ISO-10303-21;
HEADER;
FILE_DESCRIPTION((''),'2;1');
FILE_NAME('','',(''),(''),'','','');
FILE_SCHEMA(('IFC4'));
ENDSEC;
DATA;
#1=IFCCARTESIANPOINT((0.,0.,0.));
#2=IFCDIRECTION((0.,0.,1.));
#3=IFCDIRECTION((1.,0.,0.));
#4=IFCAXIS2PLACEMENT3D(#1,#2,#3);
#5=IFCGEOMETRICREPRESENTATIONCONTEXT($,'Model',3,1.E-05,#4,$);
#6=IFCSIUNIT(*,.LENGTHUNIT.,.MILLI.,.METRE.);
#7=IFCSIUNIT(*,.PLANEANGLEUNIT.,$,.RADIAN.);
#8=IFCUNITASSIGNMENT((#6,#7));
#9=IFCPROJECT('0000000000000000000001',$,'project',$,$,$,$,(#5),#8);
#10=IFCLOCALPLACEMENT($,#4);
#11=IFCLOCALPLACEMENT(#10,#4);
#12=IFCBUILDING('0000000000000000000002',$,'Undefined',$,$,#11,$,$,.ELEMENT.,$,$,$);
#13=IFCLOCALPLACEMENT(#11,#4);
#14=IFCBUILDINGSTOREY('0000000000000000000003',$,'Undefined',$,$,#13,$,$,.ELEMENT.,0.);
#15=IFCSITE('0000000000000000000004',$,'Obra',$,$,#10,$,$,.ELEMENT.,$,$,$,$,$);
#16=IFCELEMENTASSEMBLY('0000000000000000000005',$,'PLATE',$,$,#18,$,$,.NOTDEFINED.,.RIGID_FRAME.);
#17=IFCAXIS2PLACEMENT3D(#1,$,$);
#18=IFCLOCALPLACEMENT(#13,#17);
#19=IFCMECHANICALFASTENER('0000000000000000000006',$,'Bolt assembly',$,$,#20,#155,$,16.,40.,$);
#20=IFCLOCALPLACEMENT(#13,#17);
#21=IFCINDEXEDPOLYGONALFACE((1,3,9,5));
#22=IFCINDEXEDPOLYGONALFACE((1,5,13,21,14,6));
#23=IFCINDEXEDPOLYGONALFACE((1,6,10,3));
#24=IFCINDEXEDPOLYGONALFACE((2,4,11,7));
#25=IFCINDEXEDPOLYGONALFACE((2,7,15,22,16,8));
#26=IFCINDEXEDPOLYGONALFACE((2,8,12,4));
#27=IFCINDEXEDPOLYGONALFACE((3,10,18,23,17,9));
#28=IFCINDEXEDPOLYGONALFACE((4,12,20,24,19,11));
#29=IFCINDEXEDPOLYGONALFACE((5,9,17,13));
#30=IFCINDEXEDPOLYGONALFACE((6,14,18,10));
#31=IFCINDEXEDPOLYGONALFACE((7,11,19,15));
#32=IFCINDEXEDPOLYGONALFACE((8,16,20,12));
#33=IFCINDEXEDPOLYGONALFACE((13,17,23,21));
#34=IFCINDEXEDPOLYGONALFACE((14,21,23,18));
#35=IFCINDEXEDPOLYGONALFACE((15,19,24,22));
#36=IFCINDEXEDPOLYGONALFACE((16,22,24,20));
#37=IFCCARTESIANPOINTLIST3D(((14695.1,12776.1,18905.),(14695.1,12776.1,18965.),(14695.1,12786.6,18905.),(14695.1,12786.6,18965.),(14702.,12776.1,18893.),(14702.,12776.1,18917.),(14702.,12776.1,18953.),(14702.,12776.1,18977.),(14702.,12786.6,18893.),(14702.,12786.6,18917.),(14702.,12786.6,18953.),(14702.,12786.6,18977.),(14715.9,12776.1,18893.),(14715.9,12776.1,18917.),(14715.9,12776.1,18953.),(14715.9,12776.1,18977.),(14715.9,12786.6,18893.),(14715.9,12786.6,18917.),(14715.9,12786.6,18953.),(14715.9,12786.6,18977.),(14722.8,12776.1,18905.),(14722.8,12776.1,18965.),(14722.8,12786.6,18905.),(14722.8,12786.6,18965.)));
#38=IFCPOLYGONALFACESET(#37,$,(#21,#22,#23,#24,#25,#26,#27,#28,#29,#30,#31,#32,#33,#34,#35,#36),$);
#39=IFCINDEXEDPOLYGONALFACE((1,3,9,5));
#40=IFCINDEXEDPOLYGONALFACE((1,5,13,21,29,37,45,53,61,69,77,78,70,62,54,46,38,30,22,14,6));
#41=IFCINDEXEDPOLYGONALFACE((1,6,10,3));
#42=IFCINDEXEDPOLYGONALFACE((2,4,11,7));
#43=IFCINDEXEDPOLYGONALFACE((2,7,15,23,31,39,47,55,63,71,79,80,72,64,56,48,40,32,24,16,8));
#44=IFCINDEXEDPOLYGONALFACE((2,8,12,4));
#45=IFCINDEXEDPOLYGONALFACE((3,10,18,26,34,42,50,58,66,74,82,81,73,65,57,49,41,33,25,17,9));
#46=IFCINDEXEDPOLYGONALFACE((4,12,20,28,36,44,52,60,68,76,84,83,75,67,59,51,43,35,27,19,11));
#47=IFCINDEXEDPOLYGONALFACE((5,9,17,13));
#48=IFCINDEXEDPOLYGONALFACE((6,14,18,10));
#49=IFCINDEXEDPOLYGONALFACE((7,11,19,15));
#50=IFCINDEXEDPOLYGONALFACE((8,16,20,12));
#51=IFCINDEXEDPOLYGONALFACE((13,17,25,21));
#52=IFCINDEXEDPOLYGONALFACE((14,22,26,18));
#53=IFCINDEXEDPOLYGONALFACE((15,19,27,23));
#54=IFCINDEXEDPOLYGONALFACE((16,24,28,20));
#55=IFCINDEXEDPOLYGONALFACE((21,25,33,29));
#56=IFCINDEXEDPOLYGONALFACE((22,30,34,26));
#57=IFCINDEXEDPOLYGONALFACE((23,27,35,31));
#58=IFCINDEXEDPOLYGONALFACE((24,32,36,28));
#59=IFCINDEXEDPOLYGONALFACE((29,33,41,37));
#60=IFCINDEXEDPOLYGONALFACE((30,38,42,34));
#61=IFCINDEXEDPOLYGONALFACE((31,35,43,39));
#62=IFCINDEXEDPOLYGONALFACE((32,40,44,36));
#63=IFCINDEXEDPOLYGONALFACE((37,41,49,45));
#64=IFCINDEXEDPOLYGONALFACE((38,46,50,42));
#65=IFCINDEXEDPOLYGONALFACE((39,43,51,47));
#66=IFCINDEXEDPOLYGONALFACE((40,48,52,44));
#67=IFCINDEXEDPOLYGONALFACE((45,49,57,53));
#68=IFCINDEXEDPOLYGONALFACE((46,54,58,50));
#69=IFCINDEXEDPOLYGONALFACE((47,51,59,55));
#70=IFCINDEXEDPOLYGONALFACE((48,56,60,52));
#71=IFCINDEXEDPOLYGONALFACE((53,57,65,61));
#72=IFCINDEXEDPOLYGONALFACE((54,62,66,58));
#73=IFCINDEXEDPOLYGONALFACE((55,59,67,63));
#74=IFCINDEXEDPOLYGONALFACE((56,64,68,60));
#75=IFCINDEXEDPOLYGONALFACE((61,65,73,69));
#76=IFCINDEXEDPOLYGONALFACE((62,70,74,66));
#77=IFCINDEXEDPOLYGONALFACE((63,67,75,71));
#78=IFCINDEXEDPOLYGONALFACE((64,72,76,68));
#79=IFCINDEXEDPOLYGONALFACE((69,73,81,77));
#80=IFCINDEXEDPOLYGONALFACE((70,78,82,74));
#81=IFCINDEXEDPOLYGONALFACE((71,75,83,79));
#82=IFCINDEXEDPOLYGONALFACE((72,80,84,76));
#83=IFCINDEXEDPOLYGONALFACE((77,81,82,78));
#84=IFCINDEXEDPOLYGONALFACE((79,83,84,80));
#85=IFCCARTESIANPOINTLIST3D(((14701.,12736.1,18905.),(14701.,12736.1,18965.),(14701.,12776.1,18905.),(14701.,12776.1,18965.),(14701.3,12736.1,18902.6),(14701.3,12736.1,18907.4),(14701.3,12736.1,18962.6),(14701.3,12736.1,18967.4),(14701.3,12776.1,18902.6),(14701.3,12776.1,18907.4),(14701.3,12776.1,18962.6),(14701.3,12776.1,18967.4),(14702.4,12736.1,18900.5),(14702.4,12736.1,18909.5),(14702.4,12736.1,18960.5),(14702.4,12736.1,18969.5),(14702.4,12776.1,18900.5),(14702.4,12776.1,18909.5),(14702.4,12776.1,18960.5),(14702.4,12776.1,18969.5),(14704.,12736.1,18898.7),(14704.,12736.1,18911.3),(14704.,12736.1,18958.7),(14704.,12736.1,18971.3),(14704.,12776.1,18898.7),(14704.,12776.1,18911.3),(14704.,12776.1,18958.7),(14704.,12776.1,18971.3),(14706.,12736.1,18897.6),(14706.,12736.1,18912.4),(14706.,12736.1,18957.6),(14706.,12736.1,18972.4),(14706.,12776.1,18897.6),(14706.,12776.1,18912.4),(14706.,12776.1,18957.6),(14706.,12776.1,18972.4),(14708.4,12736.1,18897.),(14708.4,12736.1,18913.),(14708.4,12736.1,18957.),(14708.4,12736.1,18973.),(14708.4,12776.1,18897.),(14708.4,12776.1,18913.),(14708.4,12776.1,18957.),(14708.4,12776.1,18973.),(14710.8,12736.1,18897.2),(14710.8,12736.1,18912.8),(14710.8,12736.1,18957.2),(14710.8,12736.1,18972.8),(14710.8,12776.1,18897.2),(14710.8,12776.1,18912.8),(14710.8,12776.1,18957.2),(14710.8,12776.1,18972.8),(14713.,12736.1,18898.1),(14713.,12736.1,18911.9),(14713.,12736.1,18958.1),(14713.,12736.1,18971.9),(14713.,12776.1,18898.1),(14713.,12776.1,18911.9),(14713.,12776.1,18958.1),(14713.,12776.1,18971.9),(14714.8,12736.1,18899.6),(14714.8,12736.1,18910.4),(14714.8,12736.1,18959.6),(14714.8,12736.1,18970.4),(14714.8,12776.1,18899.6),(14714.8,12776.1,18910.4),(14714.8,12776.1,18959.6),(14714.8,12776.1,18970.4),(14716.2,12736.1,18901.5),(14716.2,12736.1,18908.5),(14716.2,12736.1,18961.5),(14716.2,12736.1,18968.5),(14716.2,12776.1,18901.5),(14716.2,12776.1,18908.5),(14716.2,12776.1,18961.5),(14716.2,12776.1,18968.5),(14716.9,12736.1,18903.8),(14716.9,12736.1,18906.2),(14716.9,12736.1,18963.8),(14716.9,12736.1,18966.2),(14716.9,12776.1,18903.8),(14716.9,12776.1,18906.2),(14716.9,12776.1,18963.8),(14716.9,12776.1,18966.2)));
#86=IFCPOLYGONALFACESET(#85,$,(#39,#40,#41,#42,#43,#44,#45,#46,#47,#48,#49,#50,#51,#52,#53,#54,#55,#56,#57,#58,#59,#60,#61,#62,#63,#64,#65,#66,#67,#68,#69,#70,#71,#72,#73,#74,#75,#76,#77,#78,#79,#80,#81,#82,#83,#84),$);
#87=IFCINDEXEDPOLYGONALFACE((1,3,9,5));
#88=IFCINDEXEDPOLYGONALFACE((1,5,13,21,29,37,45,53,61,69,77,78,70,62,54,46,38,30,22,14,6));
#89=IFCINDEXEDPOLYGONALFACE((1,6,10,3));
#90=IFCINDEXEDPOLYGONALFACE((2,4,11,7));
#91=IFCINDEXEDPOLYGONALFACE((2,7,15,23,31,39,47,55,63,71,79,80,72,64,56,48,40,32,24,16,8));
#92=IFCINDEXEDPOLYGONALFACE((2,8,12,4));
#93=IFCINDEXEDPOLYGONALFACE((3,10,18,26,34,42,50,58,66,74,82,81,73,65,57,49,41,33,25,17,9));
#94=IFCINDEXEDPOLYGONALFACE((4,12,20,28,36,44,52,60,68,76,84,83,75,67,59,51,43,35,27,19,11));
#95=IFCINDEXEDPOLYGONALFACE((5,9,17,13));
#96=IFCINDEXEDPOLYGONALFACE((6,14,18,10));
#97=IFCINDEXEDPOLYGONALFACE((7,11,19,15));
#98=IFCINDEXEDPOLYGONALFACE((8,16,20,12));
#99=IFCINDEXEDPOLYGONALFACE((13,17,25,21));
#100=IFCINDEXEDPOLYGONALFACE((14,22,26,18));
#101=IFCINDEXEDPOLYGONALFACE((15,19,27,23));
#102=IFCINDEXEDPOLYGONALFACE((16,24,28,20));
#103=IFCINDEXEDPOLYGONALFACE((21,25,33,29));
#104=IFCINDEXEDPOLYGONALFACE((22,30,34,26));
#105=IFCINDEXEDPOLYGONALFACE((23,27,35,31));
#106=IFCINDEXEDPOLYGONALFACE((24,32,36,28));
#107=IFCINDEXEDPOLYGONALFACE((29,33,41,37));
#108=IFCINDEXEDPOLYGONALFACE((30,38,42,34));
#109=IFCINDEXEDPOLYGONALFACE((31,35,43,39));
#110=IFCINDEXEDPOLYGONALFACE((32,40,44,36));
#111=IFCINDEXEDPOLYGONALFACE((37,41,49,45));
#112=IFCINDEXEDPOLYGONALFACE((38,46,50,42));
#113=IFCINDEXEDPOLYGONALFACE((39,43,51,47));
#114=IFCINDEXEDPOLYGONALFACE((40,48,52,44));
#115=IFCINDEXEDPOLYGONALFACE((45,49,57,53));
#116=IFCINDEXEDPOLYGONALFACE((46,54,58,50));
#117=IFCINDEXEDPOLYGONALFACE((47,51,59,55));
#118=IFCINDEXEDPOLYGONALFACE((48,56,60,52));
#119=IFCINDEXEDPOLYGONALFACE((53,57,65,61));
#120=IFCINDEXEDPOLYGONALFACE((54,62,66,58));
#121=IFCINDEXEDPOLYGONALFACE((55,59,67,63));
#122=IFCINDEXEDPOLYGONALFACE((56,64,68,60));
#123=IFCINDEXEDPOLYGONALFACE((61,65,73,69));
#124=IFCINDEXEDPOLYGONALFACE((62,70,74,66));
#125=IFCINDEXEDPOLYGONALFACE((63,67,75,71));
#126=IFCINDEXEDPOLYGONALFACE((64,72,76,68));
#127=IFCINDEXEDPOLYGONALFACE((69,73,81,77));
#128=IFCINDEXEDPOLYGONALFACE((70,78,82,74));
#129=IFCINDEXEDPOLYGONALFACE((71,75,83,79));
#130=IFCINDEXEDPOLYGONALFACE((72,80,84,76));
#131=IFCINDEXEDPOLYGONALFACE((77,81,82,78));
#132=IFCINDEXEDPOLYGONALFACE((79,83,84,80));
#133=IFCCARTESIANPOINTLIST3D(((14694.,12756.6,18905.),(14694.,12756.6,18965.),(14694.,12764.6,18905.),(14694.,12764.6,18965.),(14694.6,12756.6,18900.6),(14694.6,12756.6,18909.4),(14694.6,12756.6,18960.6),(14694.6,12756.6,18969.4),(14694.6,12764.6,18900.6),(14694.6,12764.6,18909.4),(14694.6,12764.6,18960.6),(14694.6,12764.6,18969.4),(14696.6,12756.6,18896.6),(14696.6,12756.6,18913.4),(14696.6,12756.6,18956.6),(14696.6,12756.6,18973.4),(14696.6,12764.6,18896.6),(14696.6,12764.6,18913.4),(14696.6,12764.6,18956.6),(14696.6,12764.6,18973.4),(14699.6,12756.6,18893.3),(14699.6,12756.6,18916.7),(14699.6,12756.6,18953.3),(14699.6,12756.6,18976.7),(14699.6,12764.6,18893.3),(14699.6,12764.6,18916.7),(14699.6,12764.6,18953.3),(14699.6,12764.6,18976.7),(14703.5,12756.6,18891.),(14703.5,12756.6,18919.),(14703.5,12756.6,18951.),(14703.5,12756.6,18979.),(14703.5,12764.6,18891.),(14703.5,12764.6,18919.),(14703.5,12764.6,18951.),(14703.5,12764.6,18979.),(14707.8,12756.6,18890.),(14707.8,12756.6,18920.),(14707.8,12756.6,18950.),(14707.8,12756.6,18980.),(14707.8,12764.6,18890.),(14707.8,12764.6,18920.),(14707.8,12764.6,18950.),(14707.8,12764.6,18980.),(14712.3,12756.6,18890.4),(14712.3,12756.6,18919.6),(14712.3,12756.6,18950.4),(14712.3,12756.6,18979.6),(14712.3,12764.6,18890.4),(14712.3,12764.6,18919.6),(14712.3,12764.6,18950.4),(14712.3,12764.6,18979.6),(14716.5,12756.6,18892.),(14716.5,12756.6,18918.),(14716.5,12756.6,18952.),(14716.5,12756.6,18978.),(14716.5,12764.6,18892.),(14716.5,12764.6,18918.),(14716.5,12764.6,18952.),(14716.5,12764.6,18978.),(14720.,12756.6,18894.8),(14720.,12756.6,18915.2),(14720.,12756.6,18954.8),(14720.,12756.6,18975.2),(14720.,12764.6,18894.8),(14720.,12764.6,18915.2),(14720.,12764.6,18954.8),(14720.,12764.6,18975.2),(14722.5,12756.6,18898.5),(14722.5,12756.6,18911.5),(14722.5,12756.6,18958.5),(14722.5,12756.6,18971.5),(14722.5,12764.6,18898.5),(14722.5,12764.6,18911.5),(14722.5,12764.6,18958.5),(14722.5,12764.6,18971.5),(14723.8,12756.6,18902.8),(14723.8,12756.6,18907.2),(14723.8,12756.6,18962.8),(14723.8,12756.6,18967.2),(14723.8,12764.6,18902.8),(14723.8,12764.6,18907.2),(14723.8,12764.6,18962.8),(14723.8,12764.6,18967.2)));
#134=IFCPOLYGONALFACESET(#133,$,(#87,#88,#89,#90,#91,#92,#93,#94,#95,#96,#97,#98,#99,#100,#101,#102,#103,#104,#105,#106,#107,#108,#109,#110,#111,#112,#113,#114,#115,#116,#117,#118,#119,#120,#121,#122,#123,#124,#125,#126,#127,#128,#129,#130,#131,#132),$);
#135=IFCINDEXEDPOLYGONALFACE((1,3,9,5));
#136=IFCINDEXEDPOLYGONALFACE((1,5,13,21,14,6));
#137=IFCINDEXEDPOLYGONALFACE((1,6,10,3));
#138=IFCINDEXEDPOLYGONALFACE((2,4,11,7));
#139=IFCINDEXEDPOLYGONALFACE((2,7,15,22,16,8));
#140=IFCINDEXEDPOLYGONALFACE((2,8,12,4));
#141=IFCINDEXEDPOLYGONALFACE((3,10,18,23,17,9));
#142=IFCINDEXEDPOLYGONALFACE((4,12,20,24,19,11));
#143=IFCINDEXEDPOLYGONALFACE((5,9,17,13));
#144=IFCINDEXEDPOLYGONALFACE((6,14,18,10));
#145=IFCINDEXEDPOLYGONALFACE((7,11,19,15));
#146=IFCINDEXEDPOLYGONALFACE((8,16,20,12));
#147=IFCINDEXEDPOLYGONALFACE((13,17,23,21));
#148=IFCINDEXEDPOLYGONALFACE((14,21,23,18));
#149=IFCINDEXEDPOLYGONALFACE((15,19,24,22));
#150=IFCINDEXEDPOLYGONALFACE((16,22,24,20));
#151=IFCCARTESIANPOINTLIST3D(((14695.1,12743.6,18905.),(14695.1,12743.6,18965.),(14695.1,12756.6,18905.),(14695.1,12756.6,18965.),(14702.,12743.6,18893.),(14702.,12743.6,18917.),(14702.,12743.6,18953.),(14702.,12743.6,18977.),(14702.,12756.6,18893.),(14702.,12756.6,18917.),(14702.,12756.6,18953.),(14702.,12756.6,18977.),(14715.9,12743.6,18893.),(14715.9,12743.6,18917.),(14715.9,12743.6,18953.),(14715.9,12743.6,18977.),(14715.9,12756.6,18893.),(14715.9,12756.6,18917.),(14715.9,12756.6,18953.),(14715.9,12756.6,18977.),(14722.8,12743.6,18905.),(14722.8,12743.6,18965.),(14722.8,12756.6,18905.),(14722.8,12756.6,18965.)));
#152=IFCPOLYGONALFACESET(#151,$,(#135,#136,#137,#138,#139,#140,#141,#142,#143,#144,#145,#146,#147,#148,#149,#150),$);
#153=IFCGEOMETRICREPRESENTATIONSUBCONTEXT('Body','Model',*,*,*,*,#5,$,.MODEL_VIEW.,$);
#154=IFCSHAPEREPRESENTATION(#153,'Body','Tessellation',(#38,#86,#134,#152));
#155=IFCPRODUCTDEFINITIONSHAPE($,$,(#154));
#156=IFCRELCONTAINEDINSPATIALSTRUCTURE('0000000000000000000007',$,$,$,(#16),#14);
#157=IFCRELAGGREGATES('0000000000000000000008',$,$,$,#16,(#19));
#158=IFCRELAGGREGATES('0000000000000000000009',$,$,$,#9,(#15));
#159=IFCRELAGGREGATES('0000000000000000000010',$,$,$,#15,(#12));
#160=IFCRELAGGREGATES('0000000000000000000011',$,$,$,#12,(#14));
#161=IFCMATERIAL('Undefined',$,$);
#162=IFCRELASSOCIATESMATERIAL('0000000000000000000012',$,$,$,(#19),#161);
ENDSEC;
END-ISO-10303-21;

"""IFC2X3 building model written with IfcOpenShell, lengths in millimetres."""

from ifc_helpers import new_model, si_unit, frame, origin_with_axes, origin_2d_with_axis, place, context, subcontext, project, spatial, polyline, circle, outline, extrude, source, transform, mapped, material, element, aggregate, save


model = new_model("IFC2X3")

# Units and contexts
model_context = context("Model", 3, precision=1e-05, world=origin_with_axes())
body_context = subcontext(model_context, "Body", "Model", "MODEL_VIEW")
ifc_project = project(units=[si_unit("LENGTHUNIT", "METRE", prefix="MILLI"), si_unit("PLANEANGLEUNIT", "RADIAN")], contexts=[model_context])

# Site, building, storey
site_placement = place(None, origin_with_axes())
site = spatial("IfcSite", under=ifc_project, at=site_placement, Name="Obra", CompositionType="ELEMENT")
building_placement = place(site_placement, origin_with_axes())
building = spatial("IfcBuilding", under=site, at=building_placement, Name="Undefined", CompositionType="ELEMENT")
storey_placement = place(building_placement, origin_with_axes())
storey = spatial("IfcBuildingStorey", under=building, at=storey_placement, Name="Undefined", CompositionType="ELEMENT", Elevation=0.0)

# Element assembly
assembly_1_placement = place(storey_placement, origin_with_axes())
assembly_1 = element("IfcElementAssembly", 1, at=assembly_1_placement, inside=storey, Name="PLATE", AssemblyPlace="NOTDEFINED", PredefinedType="RIGID_FRAME")

# Mechanical fastener
ifc_material_1 = material(Name="Undefined")
shared_shape_1 = source(origin_with_axes(), body_context, "Body", "SweptSolid", [
    extrude(outline(polyline([(13.9, 0.0), (6.9, 12.0), (-6.9, 12.0), (-13.9, 0.0), (-6.9, -12.0), (6.9, -12.0), (13.9, 0.0)])), frame((0.0, -16.6, 0.0), z_axis=(0.0, 1.0, 0.0), x_axis=(1.0, 0.0, 0.0)), (0.0, 0.0, 1.0), 10.6),
    extrude(circle(Radius=8.0, at=origin_2d_with_axis()), frame((0.0, -6.0, 0.0), z_axis=(0.0, 1.0, 0.0), x_axis=(1.0, 0.0, 0.0)), (0.0, 0.0, 1.0), 40.0),
    extrude(circle(Radius=15.0, at=origin_2d_with_axis()), frame((0.0, 5.5, 0.0), z_axis=(0.0, 1.0, 0.0), x_axis=(1.0, 0.0, 0.0)), (0.0, 0.0, 1.0), 8.0),
    extrude(outline(polyline([(13.9, 0.0), (6.9, 12.0), (-6.9, 12.0), (-13.9, 0.0), (-6.9, -12.0), (6.9, -12.0), (13.9, 0.0)])), frame((0.0, 13.5, 0.0), z_axis=(0.0, 1.0, 0.0), x_axis=(1.0, 0.0, 0.0)), (0.0, 0.0, 1.0), 13.0),
])
mechanical_fastener_1_placement = place(assembly_1_placement, frame((14709.0, 12770.1, 18935.0), z_axis=(0.0, 0.0, 1.0), x_axis=(-1.0, 0.0, 0.0)))
mechanical_fastener_1 = element("IfcMechanicalFastener", 2, at=mechanical_fastener_1_placement, material=ifc_material_1, Name="Bolt assembly", NominalDiameter=16.0, NominalLength=40.0, context=body_context, shape_type="MappedRepresentation", body=[
    mapped(shared_shape_1, transform((0.0, 0.0, -30.0))),
    mapped(shared_shape_1, transform((0.0, 0.0, 30.0))),
])
aggregate(assembly_1, [mechanical_fastener_1])

save(model, "model.ifc")
